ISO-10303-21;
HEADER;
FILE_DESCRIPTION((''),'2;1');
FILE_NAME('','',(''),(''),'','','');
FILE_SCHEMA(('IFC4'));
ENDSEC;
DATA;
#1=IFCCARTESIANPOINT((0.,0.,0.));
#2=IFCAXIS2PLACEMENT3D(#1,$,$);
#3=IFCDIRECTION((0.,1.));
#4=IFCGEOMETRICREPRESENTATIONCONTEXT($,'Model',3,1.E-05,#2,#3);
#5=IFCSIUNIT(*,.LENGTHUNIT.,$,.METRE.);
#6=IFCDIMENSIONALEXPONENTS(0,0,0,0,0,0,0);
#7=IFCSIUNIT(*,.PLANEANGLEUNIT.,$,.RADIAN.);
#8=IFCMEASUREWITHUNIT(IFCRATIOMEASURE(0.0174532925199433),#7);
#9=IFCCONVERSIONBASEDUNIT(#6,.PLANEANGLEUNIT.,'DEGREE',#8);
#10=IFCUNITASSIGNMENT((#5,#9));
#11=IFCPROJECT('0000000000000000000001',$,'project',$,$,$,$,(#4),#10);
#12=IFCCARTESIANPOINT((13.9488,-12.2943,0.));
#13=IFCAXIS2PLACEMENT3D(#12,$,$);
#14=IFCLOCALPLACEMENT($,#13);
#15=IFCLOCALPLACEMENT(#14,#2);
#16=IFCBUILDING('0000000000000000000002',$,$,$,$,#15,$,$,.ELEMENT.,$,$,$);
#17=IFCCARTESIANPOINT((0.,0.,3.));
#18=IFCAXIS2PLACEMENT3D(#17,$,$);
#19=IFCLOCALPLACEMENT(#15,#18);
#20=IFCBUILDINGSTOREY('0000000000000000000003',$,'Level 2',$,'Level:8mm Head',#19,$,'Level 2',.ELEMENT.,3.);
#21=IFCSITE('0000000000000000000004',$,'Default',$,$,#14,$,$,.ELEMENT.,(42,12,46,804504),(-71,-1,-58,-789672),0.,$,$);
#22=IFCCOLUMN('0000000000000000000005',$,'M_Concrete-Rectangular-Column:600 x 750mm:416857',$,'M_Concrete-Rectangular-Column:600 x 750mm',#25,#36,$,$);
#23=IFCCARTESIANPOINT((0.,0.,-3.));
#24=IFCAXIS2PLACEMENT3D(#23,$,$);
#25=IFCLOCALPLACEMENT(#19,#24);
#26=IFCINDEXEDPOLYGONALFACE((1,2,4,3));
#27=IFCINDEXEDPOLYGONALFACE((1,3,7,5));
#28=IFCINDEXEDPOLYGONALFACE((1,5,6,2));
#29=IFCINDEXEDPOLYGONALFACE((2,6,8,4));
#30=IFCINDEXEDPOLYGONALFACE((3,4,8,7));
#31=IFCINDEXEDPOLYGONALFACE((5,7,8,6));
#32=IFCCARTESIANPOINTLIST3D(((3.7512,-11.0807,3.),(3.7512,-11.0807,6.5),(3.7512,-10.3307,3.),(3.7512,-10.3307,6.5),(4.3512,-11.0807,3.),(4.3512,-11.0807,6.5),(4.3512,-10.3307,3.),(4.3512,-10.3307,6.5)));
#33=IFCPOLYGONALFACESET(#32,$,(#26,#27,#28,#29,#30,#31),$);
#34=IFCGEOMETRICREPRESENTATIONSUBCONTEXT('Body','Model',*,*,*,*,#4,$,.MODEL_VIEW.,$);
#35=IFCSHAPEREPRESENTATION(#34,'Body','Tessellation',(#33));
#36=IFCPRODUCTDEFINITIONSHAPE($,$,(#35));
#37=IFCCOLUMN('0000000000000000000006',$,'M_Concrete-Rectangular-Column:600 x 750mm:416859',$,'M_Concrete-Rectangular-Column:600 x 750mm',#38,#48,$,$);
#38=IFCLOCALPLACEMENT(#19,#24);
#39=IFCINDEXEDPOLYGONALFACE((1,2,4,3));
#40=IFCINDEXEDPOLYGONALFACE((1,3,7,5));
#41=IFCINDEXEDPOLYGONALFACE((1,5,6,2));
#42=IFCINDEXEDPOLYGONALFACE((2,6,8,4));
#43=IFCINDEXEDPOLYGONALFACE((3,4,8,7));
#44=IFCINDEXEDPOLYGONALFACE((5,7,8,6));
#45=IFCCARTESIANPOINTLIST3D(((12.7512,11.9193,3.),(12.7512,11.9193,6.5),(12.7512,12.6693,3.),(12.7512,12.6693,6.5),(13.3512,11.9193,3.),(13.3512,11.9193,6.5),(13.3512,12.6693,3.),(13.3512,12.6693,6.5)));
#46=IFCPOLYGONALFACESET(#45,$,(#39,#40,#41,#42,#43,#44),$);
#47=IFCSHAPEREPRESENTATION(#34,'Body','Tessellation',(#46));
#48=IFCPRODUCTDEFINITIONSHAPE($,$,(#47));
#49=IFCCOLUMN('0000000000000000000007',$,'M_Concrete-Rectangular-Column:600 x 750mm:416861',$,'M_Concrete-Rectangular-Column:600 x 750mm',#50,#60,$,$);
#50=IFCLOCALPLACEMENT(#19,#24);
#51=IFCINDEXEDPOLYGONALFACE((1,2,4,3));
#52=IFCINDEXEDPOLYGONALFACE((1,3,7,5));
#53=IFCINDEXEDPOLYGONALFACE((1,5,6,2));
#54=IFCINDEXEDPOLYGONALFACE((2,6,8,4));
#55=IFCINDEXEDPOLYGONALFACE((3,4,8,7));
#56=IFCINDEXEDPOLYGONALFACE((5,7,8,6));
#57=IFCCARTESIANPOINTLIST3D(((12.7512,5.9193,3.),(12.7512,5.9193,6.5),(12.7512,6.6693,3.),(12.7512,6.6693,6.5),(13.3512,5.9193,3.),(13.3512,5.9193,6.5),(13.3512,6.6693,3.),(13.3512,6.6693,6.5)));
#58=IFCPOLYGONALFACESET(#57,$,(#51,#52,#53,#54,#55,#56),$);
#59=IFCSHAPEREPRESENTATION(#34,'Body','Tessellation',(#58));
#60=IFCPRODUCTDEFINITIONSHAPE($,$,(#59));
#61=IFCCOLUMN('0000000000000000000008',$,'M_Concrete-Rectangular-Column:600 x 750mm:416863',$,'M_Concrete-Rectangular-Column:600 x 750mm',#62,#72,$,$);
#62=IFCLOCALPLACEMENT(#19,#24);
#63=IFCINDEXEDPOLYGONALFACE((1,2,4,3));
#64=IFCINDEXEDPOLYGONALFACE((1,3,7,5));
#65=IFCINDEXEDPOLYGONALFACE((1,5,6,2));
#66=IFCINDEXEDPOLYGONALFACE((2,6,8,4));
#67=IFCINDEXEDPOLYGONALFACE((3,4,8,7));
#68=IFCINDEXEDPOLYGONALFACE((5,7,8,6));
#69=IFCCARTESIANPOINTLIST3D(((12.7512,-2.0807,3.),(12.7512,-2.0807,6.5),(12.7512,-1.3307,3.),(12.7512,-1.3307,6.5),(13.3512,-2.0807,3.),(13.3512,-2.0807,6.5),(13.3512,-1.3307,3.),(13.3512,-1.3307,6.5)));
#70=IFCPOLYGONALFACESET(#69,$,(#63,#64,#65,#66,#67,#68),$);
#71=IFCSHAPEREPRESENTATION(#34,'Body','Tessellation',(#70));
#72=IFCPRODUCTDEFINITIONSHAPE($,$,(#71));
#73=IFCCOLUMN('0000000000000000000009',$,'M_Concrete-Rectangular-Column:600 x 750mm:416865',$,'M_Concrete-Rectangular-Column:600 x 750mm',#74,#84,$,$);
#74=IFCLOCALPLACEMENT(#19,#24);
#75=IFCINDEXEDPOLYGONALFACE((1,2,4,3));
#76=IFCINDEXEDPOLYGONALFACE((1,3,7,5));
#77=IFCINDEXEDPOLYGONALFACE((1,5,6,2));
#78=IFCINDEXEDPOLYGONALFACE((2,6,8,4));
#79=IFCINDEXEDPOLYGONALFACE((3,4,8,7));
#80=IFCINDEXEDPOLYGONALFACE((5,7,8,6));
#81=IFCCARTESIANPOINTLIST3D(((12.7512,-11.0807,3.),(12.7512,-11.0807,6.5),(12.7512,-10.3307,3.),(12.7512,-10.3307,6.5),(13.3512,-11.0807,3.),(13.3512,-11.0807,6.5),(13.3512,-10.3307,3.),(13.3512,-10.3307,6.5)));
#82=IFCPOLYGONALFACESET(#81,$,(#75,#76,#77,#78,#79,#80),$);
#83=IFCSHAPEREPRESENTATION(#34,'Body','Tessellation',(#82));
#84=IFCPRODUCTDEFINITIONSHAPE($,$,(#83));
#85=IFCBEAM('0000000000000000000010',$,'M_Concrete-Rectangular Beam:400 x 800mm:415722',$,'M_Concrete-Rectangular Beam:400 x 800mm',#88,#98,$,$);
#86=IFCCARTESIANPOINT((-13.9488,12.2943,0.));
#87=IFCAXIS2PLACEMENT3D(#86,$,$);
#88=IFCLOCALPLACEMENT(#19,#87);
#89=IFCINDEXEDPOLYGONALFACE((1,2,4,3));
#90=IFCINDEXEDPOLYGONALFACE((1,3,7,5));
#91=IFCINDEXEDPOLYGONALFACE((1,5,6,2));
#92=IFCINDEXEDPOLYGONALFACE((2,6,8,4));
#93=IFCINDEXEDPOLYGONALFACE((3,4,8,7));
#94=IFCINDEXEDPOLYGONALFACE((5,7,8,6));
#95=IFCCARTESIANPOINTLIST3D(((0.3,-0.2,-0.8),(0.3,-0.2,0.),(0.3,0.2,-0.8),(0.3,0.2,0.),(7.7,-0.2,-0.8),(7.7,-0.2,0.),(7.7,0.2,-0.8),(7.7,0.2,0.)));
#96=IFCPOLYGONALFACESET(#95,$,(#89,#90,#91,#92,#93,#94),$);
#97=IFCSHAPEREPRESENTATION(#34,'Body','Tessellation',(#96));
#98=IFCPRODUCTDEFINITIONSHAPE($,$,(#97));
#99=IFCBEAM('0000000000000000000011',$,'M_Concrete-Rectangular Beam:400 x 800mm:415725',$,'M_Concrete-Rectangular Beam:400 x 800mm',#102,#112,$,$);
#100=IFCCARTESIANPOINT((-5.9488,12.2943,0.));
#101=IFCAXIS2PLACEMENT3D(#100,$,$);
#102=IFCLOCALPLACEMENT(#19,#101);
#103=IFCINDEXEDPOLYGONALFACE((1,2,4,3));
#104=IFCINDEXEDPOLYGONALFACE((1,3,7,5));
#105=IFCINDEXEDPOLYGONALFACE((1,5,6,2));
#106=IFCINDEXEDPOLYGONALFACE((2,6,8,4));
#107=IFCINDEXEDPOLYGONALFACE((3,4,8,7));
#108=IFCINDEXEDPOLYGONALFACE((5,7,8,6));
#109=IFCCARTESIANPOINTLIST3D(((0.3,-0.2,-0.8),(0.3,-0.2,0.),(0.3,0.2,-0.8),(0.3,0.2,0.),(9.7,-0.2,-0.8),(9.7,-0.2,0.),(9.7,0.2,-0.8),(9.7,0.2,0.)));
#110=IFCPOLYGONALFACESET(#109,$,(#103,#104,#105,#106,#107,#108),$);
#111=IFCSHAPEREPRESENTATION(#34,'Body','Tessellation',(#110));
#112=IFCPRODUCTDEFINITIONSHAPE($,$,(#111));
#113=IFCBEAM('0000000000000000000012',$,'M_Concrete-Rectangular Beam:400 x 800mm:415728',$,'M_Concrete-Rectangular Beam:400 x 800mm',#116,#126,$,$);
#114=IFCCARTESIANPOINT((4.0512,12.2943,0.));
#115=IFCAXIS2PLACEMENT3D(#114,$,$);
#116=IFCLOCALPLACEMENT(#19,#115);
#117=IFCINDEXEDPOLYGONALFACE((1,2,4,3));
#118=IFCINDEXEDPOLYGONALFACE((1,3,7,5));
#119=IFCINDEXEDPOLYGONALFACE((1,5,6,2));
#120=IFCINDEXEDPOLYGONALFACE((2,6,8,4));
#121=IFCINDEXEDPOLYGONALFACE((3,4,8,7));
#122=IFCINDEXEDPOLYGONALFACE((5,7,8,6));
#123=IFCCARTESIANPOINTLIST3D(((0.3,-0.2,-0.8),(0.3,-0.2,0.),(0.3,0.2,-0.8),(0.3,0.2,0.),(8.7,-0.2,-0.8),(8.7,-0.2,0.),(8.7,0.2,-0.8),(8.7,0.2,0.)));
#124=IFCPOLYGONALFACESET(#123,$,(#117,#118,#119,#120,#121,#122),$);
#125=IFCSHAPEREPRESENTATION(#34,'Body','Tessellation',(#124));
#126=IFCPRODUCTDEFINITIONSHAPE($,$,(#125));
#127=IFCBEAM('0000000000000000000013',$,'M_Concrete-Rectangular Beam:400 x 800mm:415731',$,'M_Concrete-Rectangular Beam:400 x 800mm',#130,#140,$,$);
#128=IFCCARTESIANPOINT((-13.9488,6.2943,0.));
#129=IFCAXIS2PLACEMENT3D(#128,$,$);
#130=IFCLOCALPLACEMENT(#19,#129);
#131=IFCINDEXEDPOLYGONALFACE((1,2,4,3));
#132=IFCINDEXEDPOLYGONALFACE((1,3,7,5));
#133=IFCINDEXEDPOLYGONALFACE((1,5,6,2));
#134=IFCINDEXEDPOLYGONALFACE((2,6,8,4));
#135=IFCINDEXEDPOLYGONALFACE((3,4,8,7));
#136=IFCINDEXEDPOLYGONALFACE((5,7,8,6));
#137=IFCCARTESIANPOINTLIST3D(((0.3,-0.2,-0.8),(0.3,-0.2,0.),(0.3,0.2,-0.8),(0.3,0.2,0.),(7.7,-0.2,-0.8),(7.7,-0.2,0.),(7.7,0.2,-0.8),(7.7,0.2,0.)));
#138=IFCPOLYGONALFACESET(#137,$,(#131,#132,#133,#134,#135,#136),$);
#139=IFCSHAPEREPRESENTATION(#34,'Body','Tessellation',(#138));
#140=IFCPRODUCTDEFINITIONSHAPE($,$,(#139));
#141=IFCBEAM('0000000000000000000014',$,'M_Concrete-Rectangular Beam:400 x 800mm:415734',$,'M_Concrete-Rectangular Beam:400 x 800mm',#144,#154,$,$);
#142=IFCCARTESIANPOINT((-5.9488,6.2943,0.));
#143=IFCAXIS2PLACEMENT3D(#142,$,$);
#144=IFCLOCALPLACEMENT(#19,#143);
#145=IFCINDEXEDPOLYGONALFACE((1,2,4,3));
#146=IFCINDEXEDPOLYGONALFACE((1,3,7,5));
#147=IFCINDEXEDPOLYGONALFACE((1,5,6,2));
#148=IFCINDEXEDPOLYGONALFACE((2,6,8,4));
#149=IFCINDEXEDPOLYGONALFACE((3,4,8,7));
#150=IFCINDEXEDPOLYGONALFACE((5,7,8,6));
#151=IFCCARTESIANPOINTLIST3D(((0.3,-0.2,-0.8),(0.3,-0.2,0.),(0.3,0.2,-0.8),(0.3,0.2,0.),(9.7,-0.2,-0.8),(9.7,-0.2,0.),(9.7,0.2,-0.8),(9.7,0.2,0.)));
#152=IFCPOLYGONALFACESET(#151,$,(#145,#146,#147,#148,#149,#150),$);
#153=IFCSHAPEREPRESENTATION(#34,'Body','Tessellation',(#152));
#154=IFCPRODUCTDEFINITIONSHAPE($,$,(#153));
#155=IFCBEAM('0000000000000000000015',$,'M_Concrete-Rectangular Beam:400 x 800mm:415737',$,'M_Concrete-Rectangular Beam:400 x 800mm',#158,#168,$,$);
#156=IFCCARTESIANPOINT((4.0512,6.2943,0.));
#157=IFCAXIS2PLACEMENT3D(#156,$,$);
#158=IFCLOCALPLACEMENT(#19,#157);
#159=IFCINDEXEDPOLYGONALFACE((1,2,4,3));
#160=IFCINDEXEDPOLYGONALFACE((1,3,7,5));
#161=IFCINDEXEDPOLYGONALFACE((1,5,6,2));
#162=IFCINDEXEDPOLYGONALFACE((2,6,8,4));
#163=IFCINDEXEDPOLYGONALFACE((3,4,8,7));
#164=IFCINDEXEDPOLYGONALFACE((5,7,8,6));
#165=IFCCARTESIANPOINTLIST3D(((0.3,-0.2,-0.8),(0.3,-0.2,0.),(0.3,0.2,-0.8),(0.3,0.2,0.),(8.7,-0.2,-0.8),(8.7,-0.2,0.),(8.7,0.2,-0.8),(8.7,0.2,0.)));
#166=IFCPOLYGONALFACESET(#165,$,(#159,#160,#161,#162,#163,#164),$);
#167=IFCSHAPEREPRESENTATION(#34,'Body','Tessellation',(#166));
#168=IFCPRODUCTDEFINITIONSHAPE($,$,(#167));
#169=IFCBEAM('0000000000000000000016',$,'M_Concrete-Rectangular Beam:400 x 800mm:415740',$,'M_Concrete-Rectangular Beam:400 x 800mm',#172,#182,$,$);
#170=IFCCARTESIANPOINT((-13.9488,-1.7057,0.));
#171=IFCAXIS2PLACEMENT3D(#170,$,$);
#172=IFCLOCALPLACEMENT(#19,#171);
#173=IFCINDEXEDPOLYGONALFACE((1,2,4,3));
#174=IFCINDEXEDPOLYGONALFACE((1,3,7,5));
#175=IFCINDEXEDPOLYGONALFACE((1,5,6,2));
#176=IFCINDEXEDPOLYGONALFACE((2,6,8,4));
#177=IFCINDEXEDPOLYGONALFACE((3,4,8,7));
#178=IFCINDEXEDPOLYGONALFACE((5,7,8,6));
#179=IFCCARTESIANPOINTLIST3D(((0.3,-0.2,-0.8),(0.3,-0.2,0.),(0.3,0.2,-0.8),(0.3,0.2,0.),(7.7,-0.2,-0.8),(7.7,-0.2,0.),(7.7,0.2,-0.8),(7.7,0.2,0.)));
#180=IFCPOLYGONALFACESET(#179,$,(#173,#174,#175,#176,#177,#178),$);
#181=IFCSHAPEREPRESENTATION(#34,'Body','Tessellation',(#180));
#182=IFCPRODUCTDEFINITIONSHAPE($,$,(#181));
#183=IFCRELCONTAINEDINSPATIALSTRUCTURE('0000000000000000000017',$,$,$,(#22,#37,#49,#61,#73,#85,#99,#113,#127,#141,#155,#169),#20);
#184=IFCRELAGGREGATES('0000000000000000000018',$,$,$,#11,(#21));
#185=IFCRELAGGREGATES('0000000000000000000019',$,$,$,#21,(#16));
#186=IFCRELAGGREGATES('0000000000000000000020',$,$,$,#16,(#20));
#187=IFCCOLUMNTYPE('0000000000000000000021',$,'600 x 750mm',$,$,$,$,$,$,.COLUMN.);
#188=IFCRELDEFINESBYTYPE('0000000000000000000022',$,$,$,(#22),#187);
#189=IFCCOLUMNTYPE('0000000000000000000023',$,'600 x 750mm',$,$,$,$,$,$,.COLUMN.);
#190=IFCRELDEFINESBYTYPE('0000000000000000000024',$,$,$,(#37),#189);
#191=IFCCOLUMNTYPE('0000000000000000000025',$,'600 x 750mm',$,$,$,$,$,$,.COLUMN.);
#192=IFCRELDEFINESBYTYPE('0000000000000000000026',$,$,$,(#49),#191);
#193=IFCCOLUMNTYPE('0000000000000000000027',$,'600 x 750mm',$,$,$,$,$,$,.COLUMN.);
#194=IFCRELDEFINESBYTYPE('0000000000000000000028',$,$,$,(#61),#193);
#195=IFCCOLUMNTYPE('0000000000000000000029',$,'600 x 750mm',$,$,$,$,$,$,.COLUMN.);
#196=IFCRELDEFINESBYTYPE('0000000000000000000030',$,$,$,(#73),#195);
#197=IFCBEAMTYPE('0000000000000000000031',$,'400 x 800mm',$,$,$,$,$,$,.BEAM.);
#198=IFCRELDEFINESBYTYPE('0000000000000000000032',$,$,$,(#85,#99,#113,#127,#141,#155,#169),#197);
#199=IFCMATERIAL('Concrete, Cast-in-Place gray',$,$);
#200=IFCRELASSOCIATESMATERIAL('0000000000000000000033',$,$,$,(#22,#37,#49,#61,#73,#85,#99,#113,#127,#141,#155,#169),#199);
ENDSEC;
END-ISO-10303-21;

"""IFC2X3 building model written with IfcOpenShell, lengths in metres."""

from ifc_helpers import new_model, entity, si_unit, converted_unit, direction, frame, frame_2d, origin, origin_2d_with_axis, place, context, subcontext, project, spatial, rectangle, extrude, source, transform, mapped, material, type_object, type_shapes, element, save


model = new_model("IFC2X3")

# Units and contexts
model_context = context("Model", 3, precision=1e-05, world=origin(), true_north=direction((0.0, 1.0)))
body_context = subcontext(model_context, "Body", "Model", "MODEL_VIEW")
ifc_project = project(units=[si_unit("LENGTHUNIT", "METRE"), converted_unit("PLANEANGLEUNIT", "DEGREE", entity("IfcRatioMeasure", 0.0174532925199433), si_unit("PLANEANGLEUNIT", "RADIAN"), dimensions=[0, 0, 0, 0, 0, 0, 0])], contexts=[model_context])

# Site, building, storey
site_placement = place(None, frame((13.9488, -12.2943, 0.0)))
site = spatial("IfcSite", under=ifc_project, at=site_placement, Name="Default", CompositionType="ELEMENT", RefLatitude=(42, 12, 46, 804504), RefLongitude=(-71, -1, -58, -789672), RefElevation=0.0)
building_placement = place(site_placement, origin())
building = spatial("IfcBuilding", under=site, at=building_placement, CompositionType="ELEMENT")
storey_placement = place(building_placement, frame((0.0, 0.0, 3.0)))
storey = spatial("IfcBuildingStorey", under=building, at=storey_placement, Name="Level 2", ObjectType="Level:8mm Head", LongName="Level 2", CompositionType="ELEMENT", Elevation=3.0)

# Columns
ifc_material = material(Name="Concrete, Cast-in-Place gray")
column_type_1 = type_object("IfcColumnType", Name="600 x 750mm", PredefinedType="COLUMN")
shared_shape_1 = source(origin(), body_context, "Body", "SweptSolid", [
    extrude(rectangle(XDim=0.75, YDim=0.6, at=origin_2d_with_axis()), frame((4.0512, -10.7057, 3.0), z_axis=(0.0, 0.0, 1.0), x_axis=(0.0, -1.0, 0.0)), (0.0, 0.0, 1.0), 3.5),
])
type_shapes(column_type_1, [shared_shape_1])
column_1_placement = place(storey_placement, frame((0.0, 0.0, -3.0)))
element("IfcColumn", 1, at=column_1_placement, inside=storey, type_object=column_type_1, material=ifc_material, Name="M_Concrete-Rectangular-Column:600 x 750mm:416857", ObjectType="M_Concrete-Rectangular-Column:600 x 750mm", context=body_context, shape_type="MappedRepresentation", body=[
    mapped(shared_shape_1, transform((0.0, 0.0, 0.0), scale=1.0)),
])
column_type_2 = type_object("IfcColumnType", Name="600 x 750mm", PredefinedType="COLUMN")
shared_shape_2 = source(origin(), body_context, "Body", "SweptSolid", [
    extrude(rectangle(XDim=0.75, YDim=0.6, at=frame_2d((0.0, 0.0), x_axis=(1.0, 0.0))), frame((13.0512, 12.2943, 3.0), z_axis=(0.0, 0.0, 1.0), x_axis=(0.0, -1.0, 0.0)), (0.0, 0.0, 1.0), 3.5),
])
type_shapes(column_type_2, [shared_shape_2])
column_2_placement = place(storey_placement, frame((0.0, 0.0, -3.0)))
element("IfcColumn", 2, at=column_2_placement, inside=storey, type_object=column_type_2, material=ifc_material, Name="M_Concrete-Rectangular-Column:600 x 750mm:416859", ObjectType="M_Concrete-Rectangular-Column:600 x 750mm", context=body_context, shape_type="MappedRepresentation", body=[
    mapped(shared_shape_2, transform((0.0, 0.0, 0.0), scale=1.0)),
])
column_type_3 = type_object("IfcColumnType", Name="600 x 750mm", PredefinedType="COLUMN")
shared_shape_3 = source(origin(), body_context, "Body", "SweptSolid", [
    extrude(rectangle(XDim=0.75, YDim=0.6, at=frame_2d((0.0, 0.0), x_axis=(1.0, 0.0))), frame((13.0512, 6.2943, 3.0), z_axis=(0.0, 0.0, 1.0), x_axis=(0.0, -1.0, 0.0)), (0.0, 0.0, 1.0), 3.5),
])
type_shapes(column_type_3, [shared_shape_3])
column_3_placement = place(storey_placement, frame((0.0, 0.0, -3.0)))
element("IfcColumn", 3, at=column_3_placement, inside=storey, type_object=column_type_3, material=ifc_material, Name="M_Concrete-Rectangular-Column:600 x 750mm:416861", ObjectType="M_Concrete-Rectangular-Column:600 x 750mm", context=body_context, shape_type="MappedRepresentation", body=[
    mapped(shared_shape_3, transform((0.0, 0.0, 0.0), scale=1.0)),
])
column_type_4 = type_object("IfcColumnType", Name="600 x 750mm", PredefinedType="COLUMN")
shared_shape_4 = source(origin(), body_context, "Body", "SweptSolid", [
    extrude(rectangle(XDim=0.75, YDim=0.6, at=frame_2d((0.0, 0.0), x_axis=(1.0, 0.0))), frame((13.0512, -1.7057, 3.0), z_axis=(0.0, 0.0, 1.0), x_axis=(0.0, -1.0, 0.0)), (0.0, 0.0, 1.0), 3.5),
])
type_shapes(column_type_4, [shared_shape_4])
column_4_placement = place(storey_placement, frame((0.0, 0.0, -3.0)))
element("IfcColumn", 4, at=column_4_placement, inside=storey, type_object=column_type_4, material=ifc_material, Name="M_Concrete-Rectangular-Column:600 x 750mm:416863", ObjectType="M_Concrete-Rectangular-Column:600 x 750mm", context=body_context, shape_type="MappedRepresentation", body=[
    mapped(shared_shape_4, transform((0.0, 0.0, 0.0), scale=1.0)),
])
column_type_5 = type_object("IfcColumnType", Name="600 x 750mm", PredefinedType="COLUMN")
shared_shape_5 = source(origin(), body_context, "Body", "SweptSolid", [
    extrude(rectangle(XDim=0.75, YDim=0.6, at=frame_2d((0.0, 0.0), x_axis=(1.0, 0.0))), frame((13.0512, -10.7057, 3.0), z_axis=(0.0, 0.0, 1.0), x_axis=(0.0, -1.0, 0.0)), (0.0, 0.0, 1.0), 3.5),
])
type_shapes(column_type_5, [shared_shape_5])
column_5_placement = place(storey_placement, frame((0.0, 0.0, -3.0)))
element("IfcColumn", 5, at=column_5_placement, inside=storey, type_object=column_type_5, material=ifc_material, Name="M_Concrete-Rectangular-Column:600 x 750mm:416865", ObjectType="M_Concrete-Rectangular-Column:600 x 750mm", context=body_context, shape_type="MappedRepresentation", body=[
    mapped(shared_shape_5, transform((0.0, 0.0, 0.0), scale=1.0)),
])

# Beams
beam_type_1 = type_object("IfcBeamType", Name="400 x 800mm", PredefinedType="BEAM")
beam_1_placement = place(storey_placement, frame((-13.9488, 12.2943, 0.0)))
element("IfcBeam", 6, at=beam_1_placement, inside=storey, type_object=beam_type_1, material=ifc_material, Name="M_Concrete-Rectangular Beam:400 x 800mm:415722", ObjectType="M_Concrete-Rectangular Beam:400 x 800mm", context=body_context, shape_type="SweptSolid", body=[
    extrude(rectangle(XDim=0.8, YDim=0.4, at=frame_2d((0.0, 0.0), x_axis=(1.0, 0.0))), frame((0.3, 0.0, -0.4), z_axis=(1.0, 0.0, 0.0), x_axis=(0.0, 0.0, -1.0)), (0.0, 0.0, 1.0), 7.4),
])
beam_2_placement = place(storey_placement, frame((-5.9488, 12.2943, 0.0)))
element("IfcBeam", 7, at=beam_2_placement, inside=storey, type_object=beam_type_1, material=ifc_material, Name="M_Concrete-Rectangular Beam:400 x 800mm:415725", ObjectType="M_Concrete-Rectangular Beam:400 x 800mm", context=body_context, shape_type="SweptSolid", body=[
    extrude(rectangle(XDim=0.8, YDim=0.4, at=frame_2d((0.0, 0.0), x_axis=(1.0, 0.0))), frame((0.3, 0.0, -0.4), z_axis=(1.0, 0.0, 0.0), x_axis=(0.0, 0.0, -1.0)), (0.0, 0.0, 1.0), 9.4),
])
beam_3_placement = place(storey_placement, frame((4.0512, 12.2943, 0.0)))
element("IfcBeam", 8, at=beam_3_placement, inside=storey, type_object=beam_type_1, material=ifc_material, Name="M_Concrete-Rectangular Beam:400 x 800mm:415728", ObjectType="M_Concrete-Rectangular Beam:400 x 800mm", context=body_context, shape_type="SweptSolid", body=[
    extrude(rectangle(XDim=0.8, YDim=0.4, at=frame_2d((0.0, 0.0), x_axis=(1.0, 0.0))), frame((0.3, 0.0, -0.4), z_axis=(1.0, 0.0, 0.0), x_axis=(0.0, 0.0, -1.0)), (0.0, 0.0, 1.0), 8.4),
])
beam_4_placement = place(storey_placement, frame((-13.9488, 6.2943, 0.0)))
element("IfcBeam", 9, at=beam_4_placement, inside=storey, type_object=beam_type_1, material=ifc_material, Name="M_Concrete-Rectangular Beam:400 x 800mm:415731", ObjectType="M_Concrete-Rectangular Beam:400 x 800mm", context=body_context, shape_type="SweptSolid", body=[
    extrude(rectangle(XDim=0.8, YDim=0.4, at=frame_2d((0.0, 0.0), x_axis=(1.0, 0.0))), frame((0.3, 0.0, -0.4), z_axis=(1.0, 0.0, 0.0), x_axis=(0.0, 0.0, -1.0)), (0.0, 0.0, 1.0), 7.4),
])
beam_5_placement = place(storey_placement, frame((-5.9488, 6.2943, 0.0)))
element("IfcBeam", 10, at=beam_5_placement, inside=storey, type_object=beam_type_1, material=ifc_material, Name="M_Concrete-Rectangular Beam:400 x 800mm:415734", ObjectType="M_Concrete-Rectangular Beam:400 x 800mm", context=body_context, shape_type="SweptSolid", body=[
    extrude(rectangle(XDim=0.8, YDim=0.4, at=frame_2d((0.0, 0.0), x_axis=(1.0, 0.0))), frame((0.3, 0.0, -0.4), z_axis=(1.0, 0.0, 0.0), x_axis=(0.0, 0.0, -1.0)), (0.0, 0.0, 1.0), 9.4),
])
beam_6_placement = place(storey_placement, frame((4.0512, 6.2943, 0.0)))
element("IfcBeam", 11, at=beam_6_placement, inside=storey, type_object=beam_type_1, material=ifc_material, Name="M_Concrete-Rectangular Beam:400 x 800mm:415737", ObjectType="M_Concrete-Rectangular Beam:400 x 800mm", context=body_context, shape_type="SweptSolid", body=[
    extrude(rectangle(XDim=0.8, YDim=0.4, at=frame_2d((0.0, 0.0), x_axis=(1.0, 0.0))), frame((0.3, 0.0, -0.4), z_axis=(1.0, 0.0, 0.0), x_axis=(0.0, 0.0, -1.0)), (0.0, 0.0, 1.0), 8.4),
])
beam_7_placement = place(storey_placement, frame((-13.9488, -1.7057, 0.0)))
element("IfcBeam", 12, at=beam_7_placement, inside=storey, type_object=beam_type_1, material=ifc_material, Name="M_Concrete-Rectangular Beam:400 x 800mm:415740", ObjectType="M_Concrete-Rectangular Beam:400 x 800mm", context=body_context, shape_type="SweptSolid", body=[
    extrude(rectangle(XDim=0.8, YDim=0.4, at=frame_2d((0.0, 0.0), x_axis=(1.0, 0.0))), frame((0.3, 0.0, -0.4), z_axis=(1.0, 0.0, 0.0), x_axis=(0.0, 0.0, -1.0)), (0.0, 0.0, 1.0), 7.4),
])

save(model, "model.ifc")
